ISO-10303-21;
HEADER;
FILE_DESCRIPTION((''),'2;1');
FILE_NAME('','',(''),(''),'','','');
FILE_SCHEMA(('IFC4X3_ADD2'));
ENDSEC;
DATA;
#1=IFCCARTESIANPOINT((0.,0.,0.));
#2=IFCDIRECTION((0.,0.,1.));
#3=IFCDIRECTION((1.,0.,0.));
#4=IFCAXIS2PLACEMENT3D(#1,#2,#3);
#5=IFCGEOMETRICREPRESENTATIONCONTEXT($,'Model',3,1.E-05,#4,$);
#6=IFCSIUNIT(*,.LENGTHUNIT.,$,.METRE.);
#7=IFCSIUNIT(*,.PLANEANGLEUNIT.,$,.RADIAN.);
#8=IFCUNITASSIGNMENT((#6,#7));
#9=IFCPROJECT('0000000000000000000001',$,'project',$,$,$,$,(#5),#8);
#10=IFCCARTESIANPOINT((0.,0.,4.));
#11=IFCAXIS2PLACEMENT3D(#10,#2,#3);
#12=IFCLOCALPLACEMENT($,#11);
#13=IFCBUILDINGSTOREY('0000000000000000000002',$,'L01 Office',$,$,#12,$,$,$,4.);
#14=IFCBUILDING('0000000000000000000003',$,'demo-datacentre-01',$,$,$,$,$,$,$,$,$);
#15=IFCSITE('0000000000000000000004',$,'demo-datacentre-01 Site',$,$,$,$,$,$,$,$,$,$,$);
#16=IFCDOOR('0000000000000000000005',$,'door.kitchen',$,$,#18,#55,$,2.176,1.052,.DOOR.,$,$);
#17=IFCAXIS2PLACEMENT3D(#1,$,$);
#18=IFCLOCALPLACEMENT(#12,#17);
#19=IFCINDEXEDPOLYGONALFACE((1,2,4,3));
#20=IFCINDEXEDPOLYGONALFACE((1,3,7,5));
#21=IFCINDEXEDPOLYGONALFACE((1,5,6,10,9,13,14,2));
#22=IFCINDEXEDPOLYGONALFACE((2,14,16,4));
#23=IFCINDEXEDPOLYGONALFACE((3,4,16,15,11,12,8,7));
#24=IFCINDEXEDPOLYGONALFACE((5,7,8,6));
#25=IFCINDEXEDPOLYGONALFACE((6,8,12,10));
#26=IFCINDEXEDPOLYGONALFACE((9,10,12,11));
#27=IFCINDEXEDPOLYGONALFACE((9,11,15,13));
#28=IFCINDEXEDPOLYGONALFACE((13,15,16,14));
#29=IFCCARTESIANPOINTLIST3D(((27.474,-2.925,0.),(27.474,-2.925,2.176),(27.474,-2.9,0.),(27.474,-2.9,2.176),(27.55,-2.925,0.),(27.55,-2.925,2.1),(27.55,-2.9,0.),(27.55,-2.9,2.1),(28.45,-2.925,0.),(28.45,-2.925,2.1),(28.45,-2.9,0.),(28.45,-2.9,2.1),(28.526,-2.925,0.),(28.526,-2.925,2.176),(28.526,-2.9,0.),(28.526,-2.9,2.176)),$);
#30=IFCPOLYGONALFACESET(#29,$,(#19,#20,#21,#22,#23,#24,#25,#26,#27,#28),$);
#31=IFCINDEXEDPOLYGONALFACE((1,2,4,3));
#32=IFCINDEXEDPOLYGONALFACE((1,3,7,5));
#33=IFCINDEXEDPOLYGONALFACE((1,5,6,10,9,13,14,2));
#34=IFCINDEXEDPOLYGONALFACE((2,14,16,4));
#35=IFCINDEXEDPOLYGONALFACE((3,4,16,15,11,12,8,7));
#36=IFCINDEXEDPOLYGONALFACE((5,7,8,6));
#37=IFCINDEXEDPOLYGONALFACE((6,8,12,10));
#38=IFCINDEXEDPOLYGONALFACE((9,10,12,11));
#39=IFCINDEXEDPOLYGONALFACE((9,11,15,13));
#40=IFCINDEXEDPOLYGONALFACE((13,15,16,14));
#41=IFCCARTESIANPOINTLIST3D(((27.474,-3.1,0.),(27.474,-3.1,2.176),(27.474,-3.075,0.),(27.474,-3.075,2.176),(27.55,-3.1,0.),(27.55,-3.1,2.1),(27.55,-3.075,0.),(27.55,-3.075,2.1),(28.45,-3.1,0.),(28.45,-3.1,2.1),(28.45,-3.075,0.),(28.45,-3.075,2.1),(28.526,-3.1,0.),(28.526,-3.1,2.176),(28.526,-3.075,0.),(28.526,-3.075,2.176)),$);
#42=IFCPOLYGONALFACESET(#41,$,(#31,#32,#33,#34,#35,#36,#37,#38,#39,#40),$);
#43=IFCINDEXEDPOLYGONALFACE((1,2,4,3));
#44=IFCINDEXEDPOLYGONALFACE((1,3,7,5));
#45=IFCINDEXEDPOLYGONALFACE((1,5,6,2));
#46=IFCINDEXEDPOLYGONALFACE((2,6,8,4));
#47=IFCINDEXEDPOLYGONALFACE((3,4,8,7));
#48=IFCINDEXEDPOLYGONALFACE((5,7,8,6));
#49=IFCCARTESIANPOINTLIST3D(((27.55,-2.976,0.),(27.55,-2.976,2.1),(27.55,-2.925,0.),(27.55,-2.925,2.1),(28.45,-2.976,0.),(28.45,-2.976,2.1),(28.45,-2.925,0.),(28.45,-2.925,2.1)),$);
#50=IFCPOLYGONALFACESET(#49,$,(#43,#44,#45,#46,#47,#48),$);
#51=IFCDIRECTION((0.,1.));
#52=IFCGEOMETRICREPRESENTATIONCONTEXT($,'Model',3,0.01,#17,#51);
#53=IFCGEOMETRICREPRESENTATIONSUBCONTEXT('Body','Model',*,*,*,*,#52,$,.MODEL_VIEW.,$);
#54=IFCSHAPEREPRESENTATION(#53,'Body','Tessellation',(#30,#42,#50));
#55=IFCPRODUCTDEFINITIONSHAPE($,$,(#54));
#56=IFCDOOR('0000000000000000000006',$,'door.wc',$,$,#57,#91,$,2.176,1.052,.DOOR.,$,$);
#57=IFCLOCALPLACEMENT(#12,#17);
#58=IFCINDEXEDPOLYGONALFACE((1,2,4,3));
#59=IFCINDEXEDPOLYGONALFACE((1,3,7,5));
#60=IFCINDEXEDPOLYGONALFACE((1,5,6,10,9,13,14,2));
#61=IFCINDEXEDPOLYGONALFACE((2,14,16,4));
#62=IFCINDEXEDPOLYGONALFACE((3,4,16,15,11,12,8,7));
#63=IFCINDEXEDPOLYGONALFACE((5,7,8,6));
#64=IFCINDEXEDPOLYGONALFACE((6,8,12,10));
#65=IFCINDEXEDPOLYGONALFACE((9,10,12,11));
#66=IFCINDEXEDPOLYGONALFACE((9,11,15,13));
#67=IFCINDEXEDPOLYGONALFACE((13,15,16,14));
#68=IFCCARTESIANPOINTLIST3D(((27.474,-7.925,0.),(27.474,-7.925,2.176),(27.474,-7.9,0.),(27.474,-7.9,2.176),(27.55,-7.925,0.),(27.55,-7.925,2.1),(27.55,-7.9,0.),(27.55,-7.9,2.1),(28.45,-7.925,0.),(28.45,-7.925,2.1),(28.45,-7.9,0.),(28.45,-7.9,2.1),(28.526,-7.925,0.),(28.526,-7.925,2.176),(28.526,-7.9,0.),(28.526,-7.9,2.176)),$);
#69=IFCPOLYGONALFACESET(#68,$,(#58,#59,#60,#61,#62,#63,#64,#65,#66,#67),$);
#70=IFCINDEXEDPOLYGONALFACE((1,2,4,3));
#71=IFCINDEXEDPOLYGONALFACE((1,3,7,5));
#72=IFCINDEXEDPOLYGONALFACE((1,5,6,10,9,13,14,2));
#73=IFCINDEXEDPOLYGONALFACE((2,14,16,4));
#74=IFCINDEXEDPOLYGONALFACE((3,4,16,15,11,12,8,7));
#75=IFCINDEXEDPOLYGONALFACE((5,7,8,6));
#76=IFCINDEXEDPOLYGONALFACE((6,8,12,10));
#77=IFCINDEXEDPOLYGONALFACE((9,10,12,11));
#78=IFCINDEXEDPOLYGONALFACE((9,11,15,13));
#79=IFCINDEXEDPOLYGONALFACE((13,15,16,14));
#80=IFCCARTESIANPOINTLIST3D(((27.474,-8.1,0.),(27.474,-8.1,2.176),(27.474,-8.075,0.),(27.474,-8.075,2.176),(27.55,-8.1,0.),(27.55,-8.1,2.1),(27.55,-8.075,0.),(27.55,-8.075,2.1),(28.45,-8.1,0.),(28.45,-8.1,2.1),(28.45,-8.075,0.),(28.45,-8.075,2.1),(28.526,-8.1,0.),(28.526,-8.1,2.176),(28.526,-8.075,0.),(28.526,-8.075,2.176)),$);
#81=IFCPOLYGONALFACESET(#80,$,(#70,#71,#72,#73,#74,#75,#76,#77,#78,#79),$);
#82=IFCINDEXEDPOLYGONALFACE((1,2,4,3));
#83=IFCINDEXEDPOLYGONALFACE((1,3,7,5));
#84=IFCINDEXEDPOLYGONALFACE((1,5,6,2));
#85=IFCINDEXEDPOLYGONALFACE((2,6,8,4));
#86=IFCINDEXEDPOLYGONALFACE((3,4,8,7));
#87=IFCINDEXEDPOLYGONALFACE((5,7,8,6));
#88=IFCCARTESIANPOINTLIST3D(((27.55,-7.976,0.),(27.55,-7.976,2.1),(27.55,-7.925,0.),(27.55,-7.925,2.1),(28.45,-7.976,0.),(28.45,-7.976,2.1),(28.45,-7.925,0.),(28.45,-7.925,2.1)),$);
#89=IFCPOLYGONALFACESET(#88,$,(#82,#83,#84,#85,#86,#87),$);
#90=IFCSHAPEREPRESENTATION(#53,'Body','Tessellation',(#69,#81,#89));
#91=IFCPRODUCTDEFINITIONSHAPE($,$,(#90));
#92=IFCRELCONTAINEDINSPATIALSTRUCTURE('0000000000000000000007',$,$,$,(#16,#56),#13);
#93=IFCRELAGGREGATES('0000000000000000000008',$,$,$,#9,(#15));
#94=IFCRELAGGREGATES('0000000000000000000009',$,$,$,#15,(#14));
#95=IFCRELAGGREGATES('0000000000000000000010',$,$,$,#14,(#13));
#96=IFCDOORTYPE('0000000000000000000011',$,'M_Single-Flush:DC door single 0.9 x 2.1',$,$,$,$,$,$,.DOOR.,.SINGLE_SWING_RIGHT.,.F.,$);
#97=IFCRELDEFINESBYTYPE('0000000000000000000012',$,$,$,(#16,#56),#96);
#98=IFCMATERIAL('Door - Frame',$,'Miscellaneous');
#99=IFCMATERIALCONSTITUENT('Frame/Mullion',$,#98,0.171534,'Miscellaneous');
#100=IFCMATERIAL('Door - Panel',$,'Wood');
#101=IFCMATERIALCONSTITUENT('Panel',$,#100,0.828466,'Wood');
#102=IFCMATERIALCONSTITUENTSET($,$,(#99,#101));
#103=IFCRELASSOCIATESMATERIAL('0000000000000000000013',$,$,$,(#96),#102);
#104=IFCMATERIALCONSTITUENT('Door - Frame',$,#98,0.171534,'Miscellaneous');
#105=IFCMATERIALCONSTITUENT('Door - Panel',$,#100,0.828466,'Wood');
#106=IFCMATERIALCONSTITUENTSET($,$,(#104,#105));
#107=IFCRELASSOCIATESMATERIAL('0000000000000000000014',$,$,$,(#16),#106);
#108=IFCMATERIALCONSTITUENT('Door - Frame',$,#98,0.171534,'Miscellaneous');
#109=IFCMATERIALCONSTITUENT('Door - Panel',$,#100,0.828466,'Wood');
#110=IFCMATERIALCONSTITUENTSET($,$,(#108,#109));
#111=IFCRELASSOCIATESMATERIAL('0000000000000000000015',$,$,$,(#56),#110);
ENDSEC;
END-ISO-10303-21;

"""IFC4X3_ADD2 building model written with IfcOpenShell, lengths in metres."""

from ifc_helpers import new_model, si_unit, direction, frame, frame_2d, origin, origin_with_axes, place, context, subcontext, project, spatial, polyline, rectangle, outline, extrude, source, transform, mapped, material, constituent, constituent_set, type_object, type_shapes, element, save


model = new_model("IFC4X3_ADD2")

# Units and contexts
model_context_1 = context("Model", 3, precision=0.01, world=origin(), true_north=direction((0.0, 1.0)))
model_context_2 = context("Model", 3, precision=1e-05, world=origin_with_axes())
body_context = subcontext(model_context_1, "Body", "Model", "MODEL_VIEW")
ifc_project = project(units=[si_unit("LENGTHUNIT", "METRE"), si_unit("PLANEANGLEUNIT", "RADIAN")], contexts=[model_context_2])

# Site, building, storey
site = spatial("IfcSite", under=ifc_project, Name="demo-datacentre-01 Site")
building = spatial("IfcBuilding", under=site, Name="demo-datacentre-01")
storey_placement = place(None, frame((0.0, 0.0, 4.0), z_axis=(0.0, 0.0, 1.0), x_axis=(1.0, 0.0, 0.0)))
storey = spatial("IfcBuildingStorey", under=building, at=storey_placement, Name="L01 Office", Elevation=4.0)

# Shared definitions
placement_1 = place(None, origin())
placement_2 = place(placement_1, origin())
placement_3 = place(placement_2, frame((0.0, 0.0, 4.0)))

# Doors
ifc_material_1 = material(Name="Door - Frame", Category="Miscellaneous")
ifc_material_2 = material(Name="Door - Panel", Category="Wood")
ifc_constituent_1 = constituent(ifc_material_1, Name="Frame/Mullion", Category="Miscellaneous", fraction=0.171534)
ifc_constituent_2 = constituent(ifc_material_2, Name="Panel", Category="Wood", fraction=0.828466)
ifc_constituent_set_1 = constituent_set(constituents=[ifc_constituent_1, ifc_constituent_2])
door_type_1 = type_object("IfcDoorType", Name="M_Single-Flush:DC door single 0.9 x 2.1", OperationType="SINGLE_SWING_RIGHT", ParameterTakesPrecedence=False, PredefinedType="DOOR", material=ifc_constituent_set_1)
shared_shape_1 = source(origin(), body_context, "Body", "SweptSolid", [
    extrude(outline(polyline([(-0.526, -1.107), (0.526, -1.107), (0.526, 1.069), (0.45, 1.069), (0.45, -1.031), (-0.45, -1.031), (-0.45, 1.069), (-0.526, 1.069), (-0.526, -1.107)])), frame((0.45, 0.15, 1.069), z_axis=(0.0, 1.0, 0.0), x_axis=(1.0, 0.0, 0.0)), (0.0, 0.0, 1.0), 0.025),
    extrude(outline(polyline([(-1.107, -0.526), (1.069, -0.526), (1.069, -0.45), (-1.031, -0.45), (-1.031, 0.45), (1.069, 0.45), (1.069, 0.526), (-1.107, 0.526), (-1.107, -0.526)])), frame((0.45, -0.025, 1.069), z_axis=(0.0, 1.0, 0.0), x_axis=(0.0, 0.0, -1.0)), (0.0, 0.0, 1.0), 0.025),
    extrude(rectangle(XDim=0.051, YDim=0.9, at=frame_2d((0.0, 0.0), x_axis=(1.0, 0.0))), frame((0.45, 0.1245, 0.0), z_axis=(0.0, 0.0, 1.0), x_axis=(0.0, 1.0, 0.0)), (0.0, 0.0, 1.0), 2.1),
])
type_shapes(door_type_1, [shared_shape_1])
ifc_constituent_3 = constituent(ifc_material_1, Name="Door - Frame", Category="Miscellaneous", fraction=0.171534)
ifc_constituent_4 = constituent(ifc_material_2, Name="Door - Panel", Category="Wood", fraction=0.828466)
ifc_constituent_set_2 = constituent_set(constituents=[ifc_constituent_3, ifc_constituent_4])
door_1_placement = place(placement_3, frame((27.55, -3.075, 0.0)))
element("IfcDoor", 1, at=door_1_placement, inside=storey, type_object=door_type_1, material=ifc_constituent_set_2, Name="door.kitchen", OverallHeight=2.176, OverallWidth=1.052, PredefinedType="DOOR", context=body_context, shape_type="MappedRepresentation", body=[
    mapped(shared_shape_1, transform((0.0, 0.0, 0.0), scale=1.0)),
])
ifc_constituent_5 = constituent(ifc_material_1, Name="Door - Frame", Category="Miscellaneous", fraction=0.171534)
ifc_constituent_6 = constituent(ifc_material_2, Name="Door - Panel", Category="Wood", fraction=0.828466)
ifc_constituent_set_3 = constituent_set(constituents=[ifc_constituent_5, ifc_constituent_6])
door_2_placement = place(placement_3, frame((27.55, -8.075, 0.0)))
element("IfcDoor", 2, at=door_2_placement, inside=storey, type_object=door_type_1, material=ifc_constituent_set_3, Name="door.wc", OverallHeight=2.176, OverallWidth=1.052, PredefinedType="DOOR", context=body_context, shape_type="MappedRepresentation", body=[
    mapped(shared_shape_1, transform((0.0, 0.0, 0.0), scale=1.0)),
])

save(model, "model.ifc")
